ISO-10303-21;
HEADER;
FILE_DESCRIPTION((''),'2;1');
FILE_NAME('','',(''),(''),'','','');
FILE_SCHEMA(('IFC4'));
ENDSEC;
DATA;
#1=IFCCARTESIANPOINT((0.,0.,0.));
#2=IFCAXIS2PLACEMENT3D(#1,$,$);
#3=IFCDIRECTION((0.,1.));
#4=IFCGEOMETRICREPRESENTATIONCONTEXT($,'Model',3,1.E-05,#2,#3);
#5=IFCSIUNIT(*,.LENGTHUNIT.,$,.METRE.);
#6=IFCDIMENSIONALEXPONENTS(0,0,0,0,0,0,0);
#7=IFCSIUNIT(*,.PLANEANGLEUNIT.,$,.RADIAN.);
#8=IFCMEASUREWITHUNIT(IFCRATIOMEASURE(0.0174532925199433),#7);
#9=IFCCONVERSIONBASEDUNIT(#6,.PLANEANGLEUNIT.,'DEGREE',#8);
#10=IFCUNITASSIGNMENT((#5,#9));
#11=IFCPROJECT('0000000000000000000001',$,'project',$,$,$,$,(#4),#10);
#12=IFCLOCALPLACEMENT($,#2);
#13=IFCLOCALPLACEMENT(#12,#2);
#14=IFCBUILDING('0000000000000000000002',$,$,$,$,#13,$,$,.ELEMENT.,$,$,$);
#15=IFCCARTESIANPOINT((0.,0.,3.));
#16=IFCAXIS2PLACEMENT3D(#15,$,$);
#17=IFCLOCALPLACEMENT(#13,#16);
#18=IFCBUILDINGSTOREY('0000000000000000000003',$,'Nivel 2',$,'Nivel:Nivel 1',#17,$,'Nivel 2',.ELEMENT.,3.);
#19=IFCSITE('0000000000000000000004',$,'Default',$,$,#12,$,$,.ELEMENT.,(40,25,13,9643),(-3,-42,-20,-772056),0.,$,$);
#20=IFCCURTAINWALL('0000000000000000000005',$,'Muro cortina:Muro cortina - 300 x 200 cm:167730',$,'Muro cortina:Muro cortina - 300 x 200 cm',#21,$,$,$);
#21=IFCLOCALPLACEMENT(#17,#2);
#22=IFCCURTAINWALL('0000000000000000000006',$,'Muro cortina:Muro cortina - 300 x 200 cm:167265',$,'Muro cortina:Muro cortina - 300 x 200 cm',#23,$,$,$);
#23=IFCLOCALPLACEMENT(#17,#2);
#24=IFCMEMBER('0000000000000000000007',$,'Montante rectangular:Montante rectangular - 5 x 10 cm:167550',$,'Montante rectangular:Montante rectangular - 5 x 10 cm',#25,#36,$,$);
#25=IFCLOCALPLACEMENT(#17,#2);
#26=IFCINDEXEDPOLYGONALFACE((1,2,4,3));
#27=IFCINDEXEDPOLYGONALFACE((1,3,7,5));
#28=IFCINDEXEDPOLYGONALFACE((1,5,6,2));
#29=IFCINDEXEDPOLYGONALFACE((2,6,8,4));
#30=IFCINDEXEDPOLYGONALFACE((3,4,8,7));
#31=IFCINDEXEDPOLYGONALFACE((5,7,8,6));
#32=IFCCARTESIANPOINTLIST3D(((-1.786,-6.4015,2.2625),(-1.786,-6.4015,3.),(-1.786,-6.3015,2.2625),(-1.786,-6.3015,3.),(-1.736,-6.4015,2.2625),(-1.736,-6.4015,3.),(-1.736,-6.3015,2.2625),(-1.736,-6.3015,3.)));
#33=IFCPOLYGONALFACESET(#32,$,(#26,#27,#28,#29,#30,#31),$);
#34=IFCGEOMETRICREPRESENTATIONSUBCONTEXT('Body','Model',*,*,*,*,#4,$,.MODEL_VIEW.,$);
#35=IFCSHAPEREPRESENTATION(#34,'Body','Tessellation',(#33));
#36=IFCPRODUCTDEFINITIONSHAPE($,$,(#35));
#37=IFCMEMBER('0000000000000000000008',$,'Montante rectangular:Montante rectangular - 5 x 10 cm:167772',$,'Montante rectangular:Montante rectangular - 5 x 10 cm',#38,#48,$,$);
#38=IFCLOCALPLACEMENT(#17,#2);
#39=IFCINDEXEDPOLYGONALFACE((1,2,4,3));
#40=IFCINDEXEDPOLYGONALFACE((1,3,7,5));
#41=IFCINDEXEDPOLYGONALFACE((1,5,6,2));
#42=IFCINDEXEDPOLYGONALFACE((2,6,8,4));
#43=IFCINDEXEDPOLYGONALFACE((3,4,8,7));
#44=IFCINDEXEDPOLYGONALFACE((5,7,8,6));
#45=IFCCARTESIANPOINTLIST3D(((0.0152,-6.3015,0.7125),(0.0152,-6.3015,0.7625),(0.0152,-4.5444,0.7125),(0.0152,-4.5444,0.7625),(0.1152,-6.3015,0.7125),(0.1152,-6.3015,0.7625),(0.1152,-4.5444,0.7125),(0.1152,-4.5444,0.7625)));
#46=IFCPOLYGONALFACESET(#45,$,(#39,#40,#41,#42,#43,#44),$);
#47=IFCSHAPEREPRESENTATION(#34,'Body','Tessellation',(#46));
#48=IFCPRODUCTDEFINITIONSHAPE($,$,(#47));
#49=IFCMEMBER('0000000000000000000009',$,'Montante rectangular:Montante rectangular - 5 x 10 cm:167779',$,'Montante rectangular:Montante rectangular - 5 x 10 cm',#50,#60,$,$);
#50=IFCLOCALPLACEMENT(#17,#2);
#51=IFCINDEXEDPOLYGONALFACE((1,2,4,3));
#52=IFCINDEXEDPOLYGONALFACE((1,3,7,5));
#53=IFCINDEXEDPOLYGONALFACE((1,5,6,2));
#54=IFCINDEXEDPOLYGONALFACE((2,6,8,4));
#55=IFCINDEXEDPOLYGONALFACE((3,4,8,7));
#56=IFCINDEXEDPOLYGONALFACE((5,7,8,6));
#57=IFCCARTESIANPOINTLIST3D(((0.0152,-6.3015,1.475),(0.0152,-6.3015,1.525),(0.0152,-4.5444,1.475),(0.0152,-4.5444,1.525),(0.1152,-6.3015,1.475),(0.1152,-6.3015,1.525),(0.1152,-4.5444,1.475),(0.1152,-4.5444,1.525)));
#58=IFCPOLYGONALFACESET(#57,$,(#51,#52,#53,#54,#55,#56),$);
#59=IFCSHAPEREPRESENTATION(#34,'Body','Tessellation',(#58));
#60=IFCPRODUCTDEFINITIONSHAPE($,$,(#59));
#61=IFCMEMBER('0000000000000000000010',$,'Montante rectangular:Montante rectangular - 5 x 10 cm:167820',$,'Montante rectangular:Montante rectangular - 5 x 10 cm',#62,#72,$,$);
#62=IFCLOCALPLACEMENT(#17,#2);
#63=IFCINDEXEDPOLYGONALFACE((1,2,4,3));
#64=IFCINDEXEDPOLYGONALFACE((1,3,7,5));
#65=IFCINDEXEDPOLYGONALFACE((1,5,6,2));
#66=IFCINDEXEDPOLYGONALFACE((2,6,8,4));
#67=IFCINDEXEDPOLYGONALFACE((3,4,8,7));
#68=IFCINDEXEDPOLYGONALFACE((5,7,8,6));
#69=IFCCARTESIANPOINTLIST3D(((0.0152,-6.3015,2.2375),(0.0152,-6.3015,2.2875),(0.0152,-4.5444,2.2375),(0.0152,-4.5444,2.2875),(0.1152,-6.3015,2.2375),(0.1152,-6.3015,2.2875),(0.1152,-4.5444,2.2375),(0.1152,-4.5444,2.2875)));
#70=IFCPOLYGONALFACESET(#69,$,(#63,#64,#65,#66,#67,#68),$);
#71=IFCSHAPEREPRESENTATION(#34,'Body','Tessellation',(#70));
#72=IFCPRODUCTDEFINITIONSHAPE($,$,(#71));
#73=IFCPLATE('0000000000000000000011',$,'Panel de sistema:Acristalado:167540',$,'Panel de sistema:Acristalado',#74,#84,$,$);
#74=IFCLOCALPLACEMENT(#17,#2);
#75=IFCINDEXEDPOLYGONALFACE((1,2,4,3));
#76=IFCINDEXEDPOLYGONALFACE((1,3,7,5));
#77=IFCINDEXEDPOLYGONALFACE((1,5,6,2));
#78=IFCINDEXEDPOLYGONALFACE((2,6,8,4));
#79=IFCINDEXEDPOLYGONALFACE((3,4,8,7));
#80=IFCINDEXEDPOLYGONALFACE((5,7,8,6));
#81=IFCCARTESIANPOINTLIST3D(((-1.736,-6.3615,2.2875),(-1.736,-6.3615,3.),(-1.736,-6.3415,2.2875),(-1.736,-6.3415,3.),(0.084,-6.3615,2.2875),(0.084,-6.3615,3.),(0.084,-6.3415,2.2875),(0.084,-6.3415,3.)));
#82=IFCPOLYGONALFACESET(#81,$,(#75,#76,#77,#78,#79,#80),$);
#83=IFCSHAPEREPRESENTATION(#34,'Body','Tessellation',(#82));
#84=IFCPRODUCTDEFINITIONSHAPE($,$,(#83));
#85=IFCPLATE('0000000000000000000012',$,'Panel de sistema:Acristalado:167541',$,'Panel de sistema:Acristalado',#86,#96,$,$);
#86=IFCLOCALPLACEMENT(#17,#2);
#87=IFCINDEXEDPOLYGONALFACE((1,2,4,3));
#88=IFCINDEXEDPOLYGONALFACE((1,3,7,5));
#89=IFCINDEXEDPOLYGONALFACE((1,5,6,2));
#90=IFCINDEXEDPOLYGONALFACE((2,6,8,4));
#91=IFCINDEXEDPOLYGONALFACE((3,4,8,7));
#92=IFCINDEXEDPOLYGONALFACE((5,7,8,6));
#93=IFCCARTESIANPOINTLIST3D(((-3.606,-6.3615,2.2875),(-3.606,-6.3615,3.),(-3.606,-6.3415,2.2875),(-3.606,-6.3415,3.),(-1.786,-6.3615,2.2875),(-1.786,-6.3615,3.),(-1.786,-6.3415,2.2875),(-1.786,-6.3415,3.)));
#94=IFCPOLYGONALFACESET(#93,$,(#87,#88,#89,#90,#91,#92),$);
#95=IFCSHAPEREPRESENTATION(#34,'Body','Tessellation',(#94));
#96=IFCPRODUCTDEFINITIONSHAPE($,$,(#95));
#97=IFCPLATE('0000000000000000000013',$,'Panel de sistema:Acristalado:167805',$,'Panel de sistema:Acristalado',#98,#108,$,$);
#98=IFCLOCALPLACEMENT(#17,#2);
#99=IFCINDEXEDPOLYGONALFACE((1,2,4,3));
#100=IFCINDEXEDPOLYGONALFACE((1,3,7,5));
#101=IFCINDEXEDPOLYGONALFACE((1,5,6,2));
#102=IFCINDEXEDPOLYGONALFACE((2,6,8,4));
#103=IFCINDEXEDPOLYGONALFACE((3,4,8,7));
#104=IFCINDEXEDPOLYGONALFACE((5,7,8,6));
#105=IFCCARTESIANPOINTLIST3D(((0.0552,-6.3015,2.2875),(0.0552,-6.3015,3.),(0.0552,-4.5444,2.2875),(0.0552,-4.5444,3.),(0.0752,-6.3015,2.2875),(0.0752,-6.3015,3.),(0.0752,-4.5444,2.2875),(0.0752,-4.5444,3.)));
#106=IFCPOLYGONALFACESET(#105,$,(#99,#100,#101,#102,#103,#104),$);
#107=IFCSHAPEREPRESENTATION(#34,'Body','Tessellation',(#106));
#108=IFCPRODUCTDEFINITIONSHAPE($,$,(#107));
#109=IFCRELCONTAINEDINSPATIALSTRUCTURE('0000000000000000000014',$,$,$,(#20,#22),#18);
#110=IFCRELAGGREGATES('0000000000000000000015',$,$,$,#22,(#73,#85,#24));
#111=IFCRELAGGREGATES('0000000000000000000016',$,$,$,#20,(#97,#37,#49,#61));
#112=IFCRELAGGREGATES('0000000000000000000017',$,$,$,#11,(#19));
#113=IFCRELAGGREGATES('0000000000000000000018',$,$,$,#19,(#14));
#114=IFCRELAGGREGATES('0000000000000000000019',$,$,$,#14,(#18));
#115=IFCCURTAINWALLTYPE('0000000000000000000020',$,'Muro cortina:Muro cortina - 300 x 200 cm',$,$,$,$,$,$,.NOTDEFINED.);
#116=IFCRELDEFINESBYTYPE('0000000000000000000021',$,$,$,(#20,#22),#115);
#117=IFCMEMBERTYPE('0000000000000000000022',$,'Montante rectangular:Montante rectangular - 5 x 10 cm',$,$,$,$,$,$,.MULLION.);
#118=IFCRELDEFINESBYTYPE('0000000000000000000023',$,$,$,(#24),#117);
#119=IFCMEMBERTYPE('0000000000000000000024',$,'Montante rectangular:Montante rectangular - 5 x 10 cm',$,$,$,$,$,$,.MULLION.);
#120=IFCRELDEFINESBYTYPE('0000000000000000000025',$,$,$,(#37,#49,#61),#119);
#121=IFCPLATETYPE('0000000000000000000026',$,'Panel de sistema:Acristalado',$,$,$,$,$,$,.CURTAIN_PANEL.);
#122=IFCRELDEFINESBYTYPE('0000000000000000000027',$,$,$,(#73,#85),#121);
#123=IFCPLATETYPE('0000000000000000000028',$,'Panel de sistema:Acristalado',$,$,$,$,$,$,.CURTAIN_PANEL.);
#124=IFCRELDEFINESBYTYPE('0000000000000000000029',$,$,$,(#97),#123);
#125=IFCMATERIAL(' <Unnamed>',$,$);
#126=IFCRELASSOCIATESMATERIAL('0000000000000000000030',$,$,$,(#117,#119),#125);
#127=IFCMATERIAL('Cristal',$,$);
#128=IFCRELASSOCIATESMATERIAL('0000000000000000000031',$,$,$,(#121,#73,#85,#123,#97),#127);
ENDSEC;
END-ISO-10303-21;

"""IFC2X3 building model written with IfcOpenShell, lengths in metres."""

from ifc_helpers import new_model, entity, si_unit, converted_unit, direction, frame, origin, origin_2d_with_axis, place, context, subcontext, project, spatial, rectangle, extrude, source, transform, mapped, material, type_object, type_shapes, element, aggregate, save


model = new_model("IFC2X3")

# Units and contexts
model_context = context("Model", 3, precision=1e-05, world=origin(), true_north=direction((0.0, 1.0)))
body_context = subcontext(model_context, "Body", "Model", "MODEL_VIEW")
ifc_project = project(units=[si_unit("LENGTHUNIT", "METRE"), converted_unit("PLANEANGLEUNIT", "DEGREE", entity("IfcRatioMeasure", 0.0174532925199433), si_unit("PLANEANGLEUNIT", "RADIAN"), dimensions=[0, 0, 0, 0, 0, 0, 0])], contexts=[model_context])

# Site, building, storey
site_placement = place(None, origin())
site = spatial("IfcSite", under=ifc_project, at=site_placement, Name="Default", CompositionType="ELEMENT", RefLatitude=(40, 25, 13, 9643), RefLongitude=(-3, -42, -20, -772056), RefElevation=0.0)
building_placement = place(site_placement, origin())
building = spatial("IfcBuilding", under=site, at=building_placement, CompositionType="ELEMENT")
storey_placement = place(building_placement, frame((0.0, 0.0, 3.0)))
storey = spatial("IfcBuildingStorey", under=building, at=storey_placement, Name="Nivel 2", ObjectType="Nivel:Nivel 1", LongName="Nivel 2", CompositionType="ELEMENT", Elevation=3.0)

# Curtain walls
curtain_wall_type = type_object("IfcCurtainWallType", Name="Muro cortina:Muro cortina - 300 x 200 cm", PredefinedType="NOTDEFINED")
curtain_wall_1_placement = place(storey_placement, frame((0.0, 0.0, -3.0)))
curtain_wall_1 = element("IfcCurtainWall", 1, at=curtain_wall_1_placement, inside=storey, type_object=curtain_wall_type, Name="Muro cortina:Muro cortina - 300 x 200 cm:167730", ObjectType="Muro cortina:Muro cortina - 300 x 200 cm")
ifc_material_1 = material(Name=" <Unnamed>")
curtain_wall_2_placement = place(storey_placement, frame((0.0, 0.0, -3.0)))
curtain_wall_2 = element("IfcCurtainWall", 2, at=curtain_wall_2_placement, inside=storey, type_object=curtain_wall_type, Name="Muro cortina:Muro cortina - 300 x 200 cm:167265", ObjectType="Muro cortina:Muro cortina - 300 x 200 cm")

# Members
member_type_1 = type_object("IfcMemberType", Name="Montante rectangular:Montante rectangular - 5 x 10 cm", PredefinedType="MULLION", material=ifc_material_1)
shared_shape_1 = source(origin(), body_context, "Body", "SweptSolid", [
    extrude(rectangle(XDim=0.1, YDim=0.05, at=origin_2d_with_axis()), frame((0.0, 0.0, -0.7375), z_axis=(0.0, 0.0, 1.0), x_axis=(0.0, -1.0, 0.0)), (0.0, 0.0, 1.0), 0.7375),
])
type_shapes(member_type_1, [shared_shape_1])
member_1_placement = place(storey_placement, frame((-1.761, -6.3515, 2.2625), z_axis=(0.0, 0.0, -1.0), x_axis=(-1.0, 0.0, 0.0)))
member_1 = element("IfcMember", 3, at=member_1_placement, type_object=member_type_1, Name="Montante rectangular:Montante rectangular - 5 x 10 cm:167550", ObjectType="Montante rectangular:Montante rectangular - 5 x 10 cm", context=body_context, shape_type="MappedRepresentation", body=[
    mapped(shared_shape_1, transform((0.0, 0.0, 0.0), scale=1.0)),
])
member_type_2 = type_object("IfcMemberType", Name="Montante rectangular:Montante rectangular - 5 x 10 cm", PredefinedType="MULLION", material=ifc_material_1)
shared_shape_2 = source(origin(), body_context, "Body", "SweptSolid", [
    extrude(rectangle(XDim=0.1, YDim=0.05, at=origin_2d_with_axis()), frame((0.0, 0.0, -1.7571), z_axis=(0.0, 0.0, 1.0), x_axis=(0.0, -1.0, 0.0)), (0.0, 0.0, 1.0), 1.7571),
])
type_shapes(member_type_2, [shared_shape_2])
member_2_placement = place(storey_placement, frame((0.0652, -6.3015, 0.7375), z_axis=(0.0, -1.0, 0.0), x_axis=(0.0, 0.0, 1.0)))
member_2 = element("IfcMember", 4, at=member_2_placement, type_object=member_type_2, Name="Montante rectangular:Montante rectangular - 5 x 10 cm:167772", ObjectType="Montante rectangular:Montante rectangular - 5 x 10 cm", context=body_context, shape_type="MappedRepresentation", body=[
    mapped(shared_shape_2, transform((0.0, 0.0, 0.0), scale=1.0)),
])
member_3_placement = place(storey_placement, frame((0.0652, -6.3015, 1.5), z_axis=(0.0, -1.0, 0.0), x_axis=(0.0, 0.0, 1.0)))
member_3 = element("IfcMember", 5, at=member_3_placement, type_object=member_type_2, Name="Montante rectangular:Montante rectangular - 5 x 10 cm:167779", ObjectType="Montante rectangular:Montante rectangular - 5 x 10 cm", context=body_context, shape_type="MappedRepresentation", body=[
    mapped(shared_shape_2, transform((0.0, 0.0, 0.0), scale=1.0)),
])
member_4_placement = place(storey_placement, frame((0.0652, -6.3015, 2.2625), z_axis=(0.0, -1.0, 0.0), x_axis=(0.0, 0.0, 1.0)))
member_4 = element("IfcMember", 6, at=member_4_placement, type_object=member_type_2, Name="Montante rectangular:Montante rectangular - 5 x 10 cm:167820", ObjectType="Montante rectangular:Montante rectangular - 5 x 10 cm", context=body_context, shape_type="MappedRepresentation", body=[
    mapped(shared_shape_2, transform((0.0, 0.0, 0.0), scale=1.0)),
])

# Plates
ifc_material_2 = material(Name="Cristal")
plate_type_1 = type_object("IfcPlateType", Name="Panel de sistema:Acristalado", PredefinedType="CURTAIN_PANEL", material=ifc_material_2)
shared_shape_3 = source(origin(), body_context, "Body", "SweptSolid", [
    extrude(rectangle(XDim=0.02, YDim=1.82, at=origin_2d_with_axis()), frame((0.0, 0.0, 0.0), z_axis=(0.0, 0.0, 1.0), x_axis=(0.0, 1.0, 0.0)), (0.0, 0.0, 1.0), 0.7125),
])
type_shapes(plate_type_1, [shared_shape_3])
plate_1_placement = place(curtain_wall_2_placement, frame((-0.826, -6.3515, 5.2875), z_axis=(0.0, 0.0, 1.0), x_axis=(-1.0, 0.0, 0.0)))
plate_1 = element("IfcPlate", 7, at=plate_1_placement, type_object=plate_type_1, material=ifc_material_2, Name="Panel de sistema:Acristalado:167540", ObjectType="Panel de sistema:Acristalado", context=body_context, shape_type="MappedRepresentation", body=[
    mapped(shared_shape_3, transform((0.0, 0.0, 0.0), scale=1.0)),
])
plate_2_placement = place(curtain_wall_2_placement, frame((-2.696, -6.3515, 5.2875), z_axis=(0.0, 0.0, 1.0), x_axis=(-1.0, 0.0, 0.0)))
plate_2 = element("IfcPlate", 8, at=plate_2_placement, type_object=plate_type_1, material=ifc_material_2, Name="Panel de sistema:Acristalado:167541", ObjectType="Panel de sistema:Acristalado", context=body_context, shape_type="MappedRepresentation", body=[
    mapped(shared_shape_3, transform((0.0, 0.0, 0.0), scale=1.0)),
])
aggregate(curtain_wall_2, [plate_1, plate_2, member_1])
plate_type_2 = type_object("IfcPlateType", Name="Panel de sistema:Acristalado", PredefinedType="CURTAIN_PANEL", material=ifc_material_2)
shared_shape_4 = source(origin(), body_context, "Body", "SweptSolid", [
    extrude(rectangle(XDim=0.02, YDim=1.7571, at=origin_2d_with_axis()), frame((0.0, 0.0, 0.0), z_axis=(0.0, 0.0, 1.0), x_axis=(0.0, 1.0, 0.0)), (0.0, 0.0, 1.0), 0.7125),
])
type_shapes(plate_type_2, [shared_shape_4])
plate_3_placement = place(curtain_wall_1_placement, frame((0.0652, -5.423, 5.2875), z_axis=(0.0, 0.0, 1.0), x_axis=(0.0, -1.0, 0.0)))
plate_3 = element("IfcPlate", 9, at=plate_3_placement, type_object=plate_type_2, material=ifc_material_2, Name="Panel de sistema:Acristalado:167805", ObjectType="Panel de sistema:Acristalado", context=body_context, shape_type="MappedRepresentation", body=[
    mapped(shared_shape_4, transform((0.0, 0.0, 0.0), scale=1.0)),
])
aggregate(curtain_wall_1, [plate_3, member_2, member_3, member_4])

save(model, "model.ifc")
